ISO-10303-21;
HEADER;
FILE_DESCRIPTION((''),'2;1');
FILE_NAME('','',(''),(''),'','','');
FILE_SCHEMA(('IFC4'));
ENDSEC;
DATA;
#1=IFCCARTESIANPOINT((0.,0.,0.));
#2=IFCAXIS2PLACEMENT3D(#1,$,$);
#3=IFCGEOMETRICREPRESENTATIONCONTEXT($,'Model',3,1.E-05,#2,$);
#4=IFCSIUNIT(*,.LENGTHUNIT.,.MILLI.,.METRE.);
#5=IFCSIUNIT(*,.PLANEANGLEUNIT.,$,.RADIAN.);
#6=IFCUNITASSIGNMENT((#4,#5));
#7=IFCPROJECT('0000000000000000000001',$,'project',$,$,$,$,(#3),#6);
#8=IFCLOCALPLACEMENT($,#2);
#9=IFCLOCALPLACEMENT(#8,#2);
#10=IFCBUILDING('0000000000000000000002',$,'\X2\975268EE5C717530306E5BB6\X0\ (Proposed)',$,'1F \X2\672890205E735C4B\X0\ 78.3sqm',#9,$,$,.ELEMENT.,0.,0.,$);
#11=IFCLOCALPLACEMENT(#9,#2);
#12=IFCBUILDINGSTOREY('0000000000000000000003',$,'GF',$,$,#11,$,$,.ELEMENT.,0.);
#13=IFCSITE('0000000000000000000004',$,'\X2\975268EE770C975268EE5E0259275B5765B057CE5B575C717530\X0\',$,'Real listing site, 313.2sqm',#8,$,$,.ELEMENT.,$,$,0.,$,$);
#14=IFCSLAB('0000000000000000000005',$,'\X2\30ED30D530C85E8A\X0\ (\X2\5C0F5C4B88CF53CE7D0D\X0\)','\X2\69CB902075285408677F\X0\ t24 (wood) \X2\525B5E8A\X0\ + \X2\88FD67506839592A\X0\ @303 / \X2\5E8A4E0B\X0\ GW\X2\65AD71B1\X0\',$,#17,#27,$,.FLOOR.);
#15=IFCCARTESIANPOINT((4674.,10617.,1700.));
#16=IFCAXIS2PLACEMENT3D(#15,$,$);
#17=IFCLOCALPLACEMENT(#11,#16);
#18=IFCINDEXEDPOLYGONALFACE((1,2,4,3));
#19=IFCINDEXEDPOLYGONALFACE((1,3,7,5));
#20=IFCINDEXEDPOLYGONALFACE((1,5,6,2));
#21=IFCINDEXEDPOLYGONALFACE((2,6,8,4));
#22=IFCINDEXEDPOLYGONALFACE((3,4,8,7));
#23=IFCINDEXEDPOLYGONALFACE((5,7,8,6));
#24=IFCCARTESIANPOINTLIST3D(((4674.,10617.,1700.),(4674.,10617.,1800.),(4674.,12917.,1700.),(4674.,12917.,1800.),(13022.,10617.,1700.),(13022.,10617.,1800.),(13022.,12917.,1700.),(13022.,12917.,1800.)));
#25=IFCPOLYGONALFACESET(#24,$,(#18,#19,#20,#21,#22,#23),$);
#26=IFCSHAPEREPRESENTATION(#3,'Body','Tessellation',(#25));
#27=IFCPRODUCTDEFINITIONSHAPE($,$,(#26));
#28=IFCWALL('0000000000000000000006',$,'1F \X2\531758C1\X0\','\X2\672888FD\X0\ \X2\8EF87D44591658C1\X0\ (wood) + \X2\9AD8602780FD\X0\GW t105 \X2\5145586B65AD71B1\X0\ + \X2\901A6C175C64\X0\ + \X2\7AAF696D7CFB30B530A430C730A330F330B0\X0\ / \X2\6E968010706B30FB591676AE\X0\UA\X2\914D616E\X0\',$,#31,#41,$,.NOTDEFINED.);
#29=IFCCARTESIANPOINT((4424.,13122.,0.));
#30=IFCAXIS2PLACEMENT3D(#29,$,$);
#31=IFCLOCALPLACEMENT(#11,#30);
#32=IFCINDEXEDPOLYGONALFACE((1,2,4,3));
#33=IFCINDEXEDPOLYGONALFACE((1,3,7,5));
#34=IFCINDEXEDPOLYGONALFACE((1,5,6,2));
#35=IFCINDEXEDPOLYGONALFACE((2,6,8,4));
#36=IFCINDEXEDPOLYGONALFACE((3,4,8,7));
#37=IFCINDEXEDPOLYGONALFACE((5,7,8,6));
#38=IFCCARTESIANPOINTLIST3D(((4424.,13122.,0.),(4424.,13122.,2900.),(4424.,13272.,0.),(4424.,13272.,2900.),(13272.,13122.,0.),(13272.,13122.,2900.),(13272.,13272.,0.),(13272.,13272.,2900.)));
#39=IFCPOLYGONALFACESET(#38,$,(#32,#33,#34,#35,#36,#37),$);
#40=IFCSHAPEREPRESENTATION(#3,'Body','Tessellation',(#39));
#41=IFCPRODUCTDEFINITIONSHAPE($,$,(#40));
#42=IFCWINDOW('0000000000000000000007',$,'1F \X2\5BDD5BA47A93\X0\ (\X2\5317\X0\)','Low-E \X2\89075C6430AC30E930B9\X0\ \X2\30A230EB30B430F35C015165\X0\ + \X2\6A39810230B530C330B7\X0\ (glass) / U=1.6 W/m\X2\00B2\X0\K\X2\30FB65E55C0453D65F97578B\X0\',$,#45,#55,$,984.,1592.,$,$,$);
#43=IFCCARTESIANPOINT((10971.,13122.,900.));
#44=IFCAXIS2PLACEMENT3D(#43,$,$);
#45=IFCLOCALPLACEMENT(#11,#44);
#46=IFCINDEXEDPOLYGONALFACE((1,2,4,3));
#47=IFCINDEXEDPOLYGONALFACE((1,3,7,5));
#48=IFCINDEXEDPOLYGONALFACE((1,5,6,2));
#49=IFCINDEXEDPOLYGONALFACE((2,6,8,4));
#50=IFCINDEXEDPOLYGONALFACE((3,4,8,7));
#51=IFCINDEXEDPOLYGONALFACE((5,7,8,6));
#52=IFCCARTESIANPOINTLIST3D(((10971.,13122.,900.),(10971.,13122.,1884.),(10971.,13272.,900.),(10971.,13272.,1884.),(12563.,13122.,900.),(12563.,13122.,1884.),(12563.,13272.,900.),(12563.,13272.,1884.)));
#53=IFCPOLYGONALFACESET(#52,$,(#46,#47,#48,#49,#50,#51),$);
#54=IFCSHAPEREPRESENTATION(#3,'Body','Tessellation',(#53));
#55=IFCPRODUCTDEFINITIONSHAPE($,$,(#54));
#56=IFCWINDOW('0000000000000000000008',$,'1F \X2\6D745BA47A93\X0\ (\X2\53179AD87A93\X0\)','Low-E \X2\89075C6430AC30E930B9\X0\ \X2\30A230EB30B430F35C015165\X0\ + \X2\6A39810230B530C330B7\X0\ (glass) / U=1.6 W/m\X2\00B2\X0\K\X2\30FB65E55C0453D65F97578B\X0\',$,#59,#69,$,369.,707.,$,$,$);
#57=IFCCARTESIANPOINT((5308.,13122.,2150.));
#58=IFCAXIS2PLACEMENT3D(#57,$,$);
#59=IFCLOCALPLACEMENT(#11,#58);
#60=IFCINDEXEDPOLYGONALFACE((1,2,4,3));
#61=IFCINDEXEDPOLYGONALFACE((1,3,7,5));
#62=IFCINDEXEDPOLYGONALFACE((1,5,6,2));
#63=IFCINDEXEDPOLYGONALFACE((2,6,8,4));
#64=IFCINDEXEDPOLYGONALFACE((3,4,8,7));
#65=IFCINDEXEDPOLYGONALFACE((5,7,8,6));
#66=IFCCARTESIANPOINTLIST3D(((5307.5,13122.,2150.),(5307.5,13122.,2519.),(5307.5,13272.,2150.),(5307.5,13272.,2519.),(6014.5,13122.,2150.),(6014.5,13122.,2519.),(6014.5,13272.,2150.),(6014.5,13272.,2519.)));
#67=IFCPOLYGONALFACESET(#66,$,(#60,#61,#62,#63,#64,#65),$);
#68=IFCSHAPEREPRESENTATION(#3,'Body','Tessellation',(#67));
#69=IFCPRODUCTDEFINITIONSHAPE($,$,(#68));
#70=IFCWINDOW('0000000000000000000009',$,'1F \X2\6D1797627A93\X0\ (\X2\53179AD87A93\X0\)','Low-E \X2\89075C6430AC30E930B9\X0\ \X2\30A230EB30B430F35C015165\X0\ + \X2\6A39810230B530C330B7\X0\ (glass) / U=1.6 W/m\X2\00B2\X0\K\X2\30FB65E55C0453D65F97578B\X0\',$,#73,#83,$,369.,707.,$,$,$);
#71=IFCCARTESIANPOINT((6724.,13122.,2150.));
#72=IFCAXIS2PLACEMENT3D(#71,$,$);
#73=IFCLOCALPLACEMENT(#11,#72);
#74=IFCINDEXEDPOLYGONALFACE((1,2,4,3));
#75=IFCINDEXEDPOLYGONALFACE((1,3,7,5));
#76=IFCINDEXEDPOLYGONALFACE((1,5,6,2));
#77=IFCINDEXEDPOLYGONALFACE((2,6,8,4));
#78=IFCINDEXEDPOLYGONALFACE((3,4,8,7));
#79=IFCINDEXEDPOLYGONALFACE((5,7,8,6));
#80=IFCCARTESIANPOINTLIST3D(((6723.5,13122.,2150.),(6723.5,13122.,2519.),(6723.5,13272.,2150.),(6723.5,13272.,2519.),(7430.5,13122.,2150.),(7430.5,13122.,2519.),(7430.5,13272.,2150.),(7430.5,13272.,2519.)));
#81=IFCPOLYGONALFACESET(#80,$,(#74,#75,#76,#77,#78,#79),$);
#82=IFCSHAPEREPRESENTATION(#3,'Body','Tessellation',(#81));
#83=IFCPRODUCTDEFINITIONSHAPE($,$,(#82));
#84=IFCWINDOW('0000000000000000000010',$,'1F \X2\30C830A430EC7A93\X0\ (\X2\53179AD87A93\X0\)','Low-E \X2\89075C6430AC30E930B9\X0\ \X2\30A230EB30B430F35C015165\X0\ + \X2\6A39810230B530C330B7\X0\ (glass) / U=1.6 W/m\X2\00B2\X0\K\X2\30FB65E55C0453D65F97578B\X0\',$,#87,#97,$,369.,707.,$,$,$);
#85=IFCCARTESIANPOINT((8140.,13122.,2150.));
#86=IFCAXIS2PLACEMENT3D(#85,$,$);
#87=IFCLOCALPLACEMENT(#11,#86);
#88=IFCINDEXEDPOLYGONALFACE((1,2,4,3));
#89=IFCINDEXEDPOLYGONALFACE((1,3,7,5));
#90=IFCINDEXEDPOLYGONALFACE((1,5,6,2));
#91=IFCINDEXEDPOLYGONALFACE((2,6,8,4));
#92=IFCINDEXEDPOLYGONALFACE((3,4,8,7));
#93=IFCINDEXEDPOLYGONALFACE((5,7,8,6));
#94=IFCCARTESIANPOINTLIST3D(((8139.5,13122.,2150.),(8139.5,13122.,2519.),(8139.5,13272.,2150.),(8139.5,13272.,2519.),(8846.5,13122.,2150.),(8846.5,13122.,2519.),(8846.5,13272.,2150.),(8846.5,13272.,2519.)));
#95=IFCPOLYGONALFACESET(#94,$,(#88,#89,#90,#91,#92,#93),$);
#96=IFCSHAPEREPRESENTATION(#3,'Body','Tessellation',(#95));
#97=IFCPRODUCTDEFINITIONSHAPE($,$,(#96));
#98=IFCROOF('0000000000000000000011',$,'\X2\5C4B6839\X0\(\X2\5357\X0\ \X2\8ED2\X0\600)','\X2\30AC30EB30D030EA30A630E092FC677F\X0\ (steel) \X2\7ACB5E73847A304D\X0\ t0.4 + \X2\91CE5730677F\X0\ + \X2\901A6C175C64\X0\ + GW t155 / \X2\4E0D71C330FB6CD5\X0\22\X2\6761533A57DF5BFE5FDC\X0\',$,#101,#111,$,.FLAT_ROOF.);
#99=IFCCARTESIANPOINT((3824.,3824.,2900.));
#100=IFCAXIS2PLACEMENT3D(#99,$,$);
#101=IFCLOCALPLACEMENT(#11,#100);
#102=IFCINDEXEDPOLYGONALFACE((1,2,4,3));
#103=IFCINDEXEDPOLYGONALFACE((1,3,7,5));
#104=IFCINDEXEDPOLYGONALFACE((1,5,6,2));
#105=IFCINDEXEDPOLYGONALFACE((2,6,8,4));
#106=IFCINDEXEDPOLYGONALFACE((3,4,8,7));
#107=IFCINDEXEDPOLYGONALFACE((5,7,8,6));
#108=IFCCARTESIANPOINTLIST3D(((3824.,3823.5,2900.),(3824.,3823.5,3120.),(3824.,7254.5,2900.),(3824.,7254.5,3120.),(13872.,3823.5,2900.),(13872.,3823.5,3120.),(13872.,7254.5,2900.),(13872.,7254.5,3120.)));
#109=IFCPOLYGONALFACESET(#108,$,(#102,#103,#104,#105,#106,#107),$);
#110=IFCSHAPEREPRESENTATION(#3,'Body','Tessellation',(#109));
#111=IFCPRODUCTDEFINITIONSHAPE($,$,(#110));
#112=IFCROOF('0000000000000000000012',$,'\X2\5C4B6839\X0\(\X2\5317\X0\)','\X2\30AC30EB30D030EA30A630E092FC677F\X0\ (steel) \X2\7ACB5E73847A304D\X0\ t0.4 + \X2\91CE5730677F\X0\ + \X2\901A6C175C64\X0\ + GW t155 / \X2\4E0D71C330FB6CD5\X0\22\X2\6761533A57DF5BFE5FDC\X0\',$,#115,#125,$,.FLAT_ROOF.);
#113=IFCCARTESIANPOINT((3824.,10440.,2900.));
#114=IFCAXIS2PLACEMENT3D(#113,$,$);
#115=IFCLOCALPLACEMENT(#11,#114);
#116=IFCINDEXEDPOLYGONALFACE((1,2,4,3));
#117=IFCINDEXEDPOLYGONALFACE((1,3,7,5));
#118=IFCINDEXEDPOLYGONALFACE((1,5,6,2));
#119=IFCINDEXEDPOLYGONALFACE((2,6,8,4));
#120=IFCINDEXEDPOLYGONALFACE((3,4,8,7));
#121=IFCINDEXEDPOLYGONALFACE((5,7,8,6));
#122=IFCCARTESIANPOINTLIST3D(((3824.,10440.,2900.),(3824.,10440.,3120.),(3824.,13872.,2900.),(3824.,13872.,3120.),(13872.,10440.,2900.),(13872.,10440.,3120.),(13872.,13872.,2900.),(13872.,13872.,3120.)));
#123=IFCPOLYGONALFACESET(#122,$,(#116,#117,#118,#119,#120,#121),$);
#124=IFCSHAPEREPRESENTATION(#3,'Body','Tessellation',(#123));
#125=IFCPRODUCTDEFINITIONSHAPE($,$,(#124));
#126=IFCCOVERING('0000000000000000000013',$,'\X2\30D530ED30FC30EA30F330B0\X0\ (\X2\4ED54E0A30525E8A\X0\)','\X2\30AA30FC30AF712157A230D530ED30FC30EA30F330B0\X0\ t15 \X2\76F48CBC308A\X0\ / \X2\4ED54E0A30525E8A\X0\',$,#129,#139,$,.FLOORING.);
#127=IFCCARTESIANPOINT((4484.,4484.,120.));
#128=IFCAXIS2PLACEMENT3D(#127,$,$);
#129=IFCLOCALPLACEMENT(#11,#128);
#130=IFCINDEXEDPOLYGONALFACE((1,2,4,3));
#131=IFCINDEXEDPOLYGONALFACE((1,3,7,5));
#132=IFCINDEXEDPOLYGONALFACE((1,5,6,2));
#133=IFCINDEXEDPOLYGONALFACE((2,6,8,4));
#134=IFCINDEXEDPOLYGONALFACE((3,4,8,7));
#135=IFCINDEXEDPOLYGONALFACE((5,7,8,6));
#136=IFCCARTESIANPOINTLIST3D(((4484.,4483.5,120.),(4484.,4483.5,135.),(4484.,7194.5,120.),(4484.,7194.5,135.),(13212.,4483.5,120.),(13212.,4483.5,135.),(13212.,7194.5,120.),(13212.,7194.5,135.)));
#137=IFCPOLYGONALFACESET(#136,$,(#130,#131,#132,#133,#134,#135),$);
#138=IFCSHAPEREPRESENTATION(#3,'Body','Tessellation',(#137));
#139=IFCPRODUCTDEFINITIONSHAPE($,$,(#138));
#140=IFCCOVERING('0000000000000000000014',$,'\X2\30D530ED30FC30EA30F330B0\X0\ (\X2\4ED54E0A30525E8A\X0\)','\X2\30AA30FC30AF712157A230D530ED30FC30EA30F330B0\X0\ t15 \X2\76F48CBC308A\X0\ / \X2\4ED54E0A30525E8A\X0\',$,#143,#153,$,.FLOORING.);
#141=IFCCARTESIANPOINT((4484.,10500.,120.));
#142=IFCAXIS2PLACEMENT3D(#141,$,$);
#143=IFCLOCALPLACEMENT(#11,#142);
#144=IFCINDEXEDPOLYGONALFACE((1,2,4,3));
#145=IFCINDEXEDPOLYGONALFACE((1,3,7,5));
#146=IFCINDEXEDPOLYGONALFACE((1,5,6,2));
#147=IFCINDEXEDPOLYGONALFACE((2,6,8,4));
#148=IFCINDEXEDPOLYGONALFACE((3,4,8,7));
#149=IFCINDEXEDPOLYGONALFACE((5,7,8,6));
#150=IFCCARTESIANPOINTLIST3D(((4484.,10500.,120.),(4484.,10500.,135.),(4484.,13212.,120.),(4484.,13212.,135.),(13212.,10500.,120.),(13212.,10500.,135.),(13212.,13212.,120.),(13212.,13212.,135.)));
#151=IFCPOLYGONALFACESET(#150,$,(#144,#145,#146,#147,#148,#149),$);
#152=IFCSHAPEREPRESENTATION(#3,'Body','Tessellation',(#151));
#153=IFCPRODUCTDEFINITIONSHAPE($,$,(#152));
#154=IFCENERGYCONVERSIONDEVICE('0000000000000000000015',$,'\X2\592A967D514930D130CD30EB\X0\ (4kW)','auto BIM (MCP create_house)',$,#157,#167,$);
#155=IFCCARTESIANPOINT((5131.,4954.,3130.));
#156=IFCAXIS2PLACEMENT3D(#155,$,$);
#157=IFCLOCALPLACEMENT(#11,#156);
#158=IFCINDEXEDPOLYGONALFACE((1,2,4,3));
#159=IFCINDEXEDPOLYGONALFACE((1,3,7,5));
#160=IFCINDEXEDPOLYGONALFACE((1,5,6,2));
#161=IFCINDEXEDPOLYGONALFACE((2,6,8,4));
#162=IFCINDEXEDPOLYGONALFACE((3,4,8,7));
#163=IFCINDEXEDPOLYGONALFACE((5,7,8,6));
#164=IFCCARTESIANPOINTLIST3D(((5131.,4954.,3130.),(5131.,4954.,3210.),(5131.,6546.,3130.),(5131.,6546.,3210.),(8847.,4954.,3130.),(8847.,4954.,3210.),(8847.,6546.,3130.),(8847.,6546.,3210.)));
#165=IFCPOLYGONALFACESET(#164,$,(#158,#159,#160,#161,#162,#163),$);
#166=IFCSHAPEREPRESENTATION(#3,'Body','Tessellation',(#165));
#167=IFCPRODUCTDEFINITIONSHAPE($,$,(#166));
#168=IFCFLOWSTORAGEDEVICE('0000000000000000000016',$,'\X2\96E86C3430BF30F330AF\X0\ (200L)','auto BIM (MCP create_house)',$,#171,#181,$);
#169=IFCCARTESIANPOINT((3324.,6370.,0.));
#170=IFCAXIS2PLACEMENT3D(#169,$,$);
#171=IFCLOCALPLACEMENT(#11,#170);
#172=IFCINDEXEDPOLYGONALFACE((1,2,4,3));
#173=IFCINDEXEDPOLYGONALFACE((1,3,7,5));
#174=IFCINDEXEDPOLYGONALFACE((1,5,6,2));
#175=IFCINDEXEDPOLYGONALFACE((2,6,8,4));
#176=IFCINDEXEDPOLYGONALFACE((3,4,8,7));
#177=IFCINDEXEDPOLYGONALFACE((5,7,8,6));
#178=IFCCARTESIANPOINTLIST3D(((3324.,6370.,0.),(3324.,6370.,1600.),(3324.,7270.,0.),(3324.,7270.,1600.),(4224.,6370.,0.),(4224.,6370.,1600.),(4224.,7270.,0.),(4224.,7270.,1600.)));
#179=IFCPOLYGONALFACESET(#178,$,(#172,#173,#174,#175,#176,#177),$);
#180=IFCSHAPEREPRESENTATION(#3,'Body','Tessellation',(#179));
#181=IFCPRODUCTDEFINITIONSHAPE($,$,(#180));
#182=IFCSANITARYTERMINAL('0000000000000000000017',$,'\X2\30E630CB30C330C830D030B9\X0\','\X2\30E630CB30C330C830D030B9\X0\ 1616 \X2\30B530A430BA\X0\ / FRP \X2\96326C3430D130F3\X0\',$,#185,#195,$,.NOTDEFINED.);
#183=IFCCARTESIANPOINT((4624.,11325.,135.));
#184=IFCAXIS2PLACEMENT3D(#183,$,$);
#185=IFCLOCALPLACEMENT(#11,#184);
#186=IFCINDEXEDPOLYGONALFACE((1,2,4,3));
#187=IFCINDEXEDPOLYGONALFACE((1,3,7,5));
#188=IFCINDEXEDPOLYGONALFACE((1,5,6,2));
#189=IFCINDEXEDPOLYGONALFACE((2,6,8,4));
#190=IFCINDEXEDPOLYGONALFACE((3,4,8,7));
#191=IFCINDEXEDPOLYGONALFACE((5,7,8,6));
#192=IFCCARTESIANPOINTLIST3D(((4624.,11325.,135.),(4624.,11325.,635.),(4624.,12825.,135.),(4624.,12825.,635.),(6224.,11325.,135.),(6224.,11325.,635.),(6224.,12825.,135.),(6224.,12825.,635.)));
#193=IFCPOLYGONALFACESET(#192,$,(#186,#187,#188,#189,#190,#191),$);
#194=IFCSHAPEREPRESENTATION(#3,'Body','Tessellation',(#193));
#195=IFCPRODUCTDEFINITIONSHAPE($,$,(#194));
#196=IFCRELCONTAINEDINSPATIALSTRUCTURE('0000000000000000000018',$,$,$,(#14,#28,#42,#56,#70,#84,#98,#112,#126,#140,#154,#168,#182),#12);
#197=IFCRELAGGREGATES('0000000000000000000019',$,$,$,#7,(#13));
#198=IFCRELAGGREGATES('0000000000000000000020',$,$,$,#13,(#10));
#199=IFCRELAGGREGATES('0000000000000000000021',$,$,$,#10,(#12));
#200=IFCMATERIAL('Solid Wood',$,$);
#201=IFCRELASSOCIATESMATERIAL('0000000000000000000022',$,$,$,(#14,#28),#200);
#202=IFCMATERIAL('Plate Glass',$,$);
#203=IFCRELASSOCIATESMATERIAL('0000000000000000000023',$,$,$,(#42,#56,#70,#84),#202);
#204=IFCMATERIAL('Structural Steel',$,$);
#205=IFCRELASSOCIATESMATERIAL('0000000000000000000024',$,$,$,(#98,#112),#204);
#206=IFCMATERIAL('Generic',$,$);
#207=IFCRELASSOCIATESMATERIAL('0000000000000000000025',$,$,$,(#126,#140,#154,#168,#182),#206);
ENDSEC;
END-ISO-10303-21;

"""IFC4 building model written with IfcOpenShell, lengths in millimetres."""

from ifc_helpers import new_model, si_unit, frame, frame_2d, origin, place, context, project, spatial, rectangle, extrude, material, element, fill, save


model = new_model("IFC4")

# Units and contexts
model_context = context("Model", 3, precision=1e-05, world=origin())
ifc_project = project(units=[si_unit("LENGTHUNIT", "METRE", prefix="MILLI"), si_unit("PLANEANGLEUNIT", "RADIAN")], contexts=[model_context])

# Site, building, storey
site_placement = place(None, origin())
site = spatial("IfcSite", under=ifc_project, at=site_placement, Name="青森県青森市大字新城字山田", ObjectType="Real listing site, 313.2sqm", CompositionType="ELEMENT", RefElevation=0.0)
building_placement = place(site_placement, origin())
building = spatial("IfcBuilding", under=site, at=building_placement, Name="青森山田の家 (Proposed)", ObjectType="1F 木造平屋 78.3sqm", CompositionType="ELEMENT", ElevationOfRefHeight=0.0, ElevationOfTerrain=0.0)
storey_placement = place(building_placement, origin())
storey = spatial("IfcBuildingStorey", under=building, at=storey_placement, Name="GF", CompositionType="ELEMENT", Elevation=0.0)

# Slab
ifc_material_1 = material(Name="Solid Wood")
slab_1_placement = place(storey_placement, frame((4674.0, 10617.0, 1700.0)))
element("IfcSlab", 1, at=slab_1_placement, inside=storey, material=ifc_material_1, Name="ロフト床 (小屋裏収納)", Description="構造用合板 t24 (wood) 剛床 + 製材根太 @303 / 床下 GW断熱", PredefinedType="FLOOR", context=model_context, shape_type="SweptSolid", body=[
    extrude(rectangle(XDim=8348.0, YDim=2300.0, at=frame_2d((4174.0, 1150.0))), frame((4674.0, 10617.0, 1700.0)), (0.0, 0.0, 1.0), 100.0),
])

# Shared definitions
ifc_material_2 = material(Name="Plate Glass")

# Wall, openings, windows
wall_1_placement = place(storey_placement, frame((4424.0, 13122.0, 0.0)))
wall_1 = element("IfcWall", 2, at=wall_1_placement, inside=storey, material=ifc_material_1, Name="1F 北壁", Description="木製 軸組外壁 (wood) + 高性能GW t105 充填断熱 + 通気層 + 窯業系サイディング / 準耐火・外皮UA配慮", PredefinedType="NOTDEFINED", context=model_context, shape_type="SweptSolid", body=[
    extrude(rectangle(XDim=8848.0, YDim=150.0, at=frame_2d((4424.0, 75.0))), frame((4424.0, 13122.0, 0.0)), (0.0, 0.0, 1.0), 2900.0),
])
opening_1_placement = place(storey_placement, frame((10971.0, 13122.0, 900.0)))
opening_1 = element("IfcOpeningElement", 3, at=opening_1_placement, cuts=wall_1, PredefinedType="NOTDEFINED", context=model_context, shape_type="SweptSolid", body=[
    extrude(rectangle(XDim=1592.0, YDim=150.0, at=frame_2d((796.0, 75.0))), frame((10971.0, 13122.0, 900.0)), (0.0, 0.0, 1.0), 984.0),
])
opening_2_placement = place(storey_placement, frame((5308.0, 13122.0, 2150.0)))
opening_2 = element("IfcOpeningElement", 4, at=opening_2_placement, cuts=wall_1, PredefinedType="NOTDEFINED", context=model_context, shape_type="SweptSolid", body=[
    extrude(rectangle(XDim=707.0, YDim=150.0, at=frame_2d((353.0, 75.0))), frame((5308.0, 13122.0, 2150.0)), (0.0, 0.0, 1.0), 369.0),
])
opening_3_placement = place(storey_placement, frame((6724.0, 13122.0, 2150.0)))
opening_3 = element("IfcOpeningElement", 5, at=opening_3_placement, cuts=wall_1, PredefinedType="NOTDEFINED", context=model_context, shape_type="SweptSolid", body=[
    extrude(rectangle(XDim=707.0, YDim=150.0, at=frame_2d((353.0, 75.0))), frame((6724.0, 13122.0, 2150.0)), (0.0, 0.0, 1.0), 369.0),
])
opening_4_placement = place(storey_placement, frame((8140.0, 13122.0, 2150.0)))
opening_4 = element("IfcOpeningElement", 6, at=opening_4_placement, cuts=wall_1, PredefinedType="NOTDEFINED", context=model_context, shape_type="SweptSolid", body=[
    extrude(rectangle(XDim=707.0, YDim=150.0, at=frame_2d((353.0, 75.0))), frame((8140.0, 13122.0, 2150.0)), (0.0, 0.0, 1.0), 369.0),
])
window_1_placement = place(storey_placement, frame((10971.0, 13122.0, 900.0)))
window_1 = element("IfcWindow", 7, at=window_1_placement, inside=storey, material=ifc_material_2, Name="1F 寝室窓 (北)", Description="Low-E 複層ガラス アルゴン封入 + 樹脂サッシ (glass) / U=1.6 W/m²K・日射取得型", OverallHeight=984.0, OverallWidth=1592.0, context=model_context, shape_type="SweptSolid", body=[
    extrude(rectangle(XDim=1592.0, YDim=150.0, at=frame_2d((796.0, 75.0))), frame((10971.0, 13122.0, 900.0)), (0.0, 0.0, 1.0), 984.0),
])
fill(opening_1, window_1)
window_2_placement = place(storey_placement, frame((5308.0, 13122.0, 2150.0)))
window_2 = element("IfcWindow", 8, at=window_2_placement, inside=storey, material=ifc_material_2, Name="1F 浴室窓 (北高窓)", Description="Low-E 複層ガラス アルゴン封入 + 樹脂サッシ (glass) / U=1.6 W/m²K・日射取得型", OverallHeight=369.0, OverallWidth=707.0, context=model_context, shape_type="SweptSolid", body=[
    extrude(rectangle(XDim=707.0, YDim=150.0, at=frame_2d((353.0, 75.0))), frame((5308.0, 13122.0, 2150.0)), (0.0, 0.0, 1.0), 369.0),
])
fill(opening_2, window_2)
window_3_placement = place(storey_placement, frame((6724.0, 13122.0, 2150.0)))
window_3 = element("IfcWindow", 9, at=window_3_placement, inside=storey, material=ifc_material_2, Name="1F 洗面窓 (北高窓)", Description="Low-E 複層ガラス アルゴン封入 + 樹脂サッシ (glass) / U=1.6 W/m²K・日射取得型", OverallHeight=369.0, OverallWidth=707.0, context=model_context, shape_type="SweptSolid", body=[
    extrude(rectangle(XDim=707.0, YDim=150.0, at=frame_2d((353.0, 75.0))), frame((6724.0, 13122.0, 2150.0)), (0.0, 0.0, 1.0), 369.0),
])
fill(opening_3, window_3)
window_4_placement = place(storey_placement, frame((8140.0, 13122.0, 2150.0)))
window_4 = element("IfcWindow", 10, at=window_4_placement, inside=storey, material=ifc_material_2, Name="1F トイレ窓 (北高窓)", Description="Low-E 複層ガラス アルゴン封入 + 樹脂サッシ (glass) / U=1.6 W/m²K・日射取得型", OverallHeight=369.0, OverallWidth=707.0, context=model_context, shape_type="SweptSolid", body=[
    extrude(rectangle(XDim=707.0, YDim=150.0, at=frame_2d((353.0, 75.0))), frame((8140.0, 13122.0, 2150.0)), (0.0, 0.0, 1.0), 369.0),
])
fill(opening_4, window_4)

# Roofs
ifc_material_3 = material(Name="Structural Steel")
roof_1_placement = place(storey_placement, frame((3824.0, 3824.0, 2900.0)))
element("IfcRoof", 11, at=roof_1_placement, inside=storey, material=ifc_material_3, Name="屋根(南 軒600)", Description="ガルバリウム鋼板 (steel) 立平葺き t0.4 + 野地板 + 通気層 + GW t155 / 不燃・法22条区域対応", PredefinedType="FLAT_ROOF", context=model_context, shape_type="SweptSolid", body=[
    extrude(rectangle(XDim=10048.0, YDim=3431.0, at=frame_2d((5024.0, 1715.0))), frame((3824.0, 3824.0, 2900.0)), (0.0, 0.0, 1.0), 220.0),
])
roof_2_placement = place(storey_placement, frame((3824.0, 10440.0, 2900.0)))
element("IfcRoof", 12, at=roof_2_placement, inside=storey, material=ifc_material_3, Name="屋根(北)", Description="ガルバリウム鋼板 (steel) 立平葺き t0.4 + 野地板 + 通気層 + GW t155 / 不燃・法22条区域対応", PredefinedType="FLAT_ROOF", context=model_context, shape_type="SweptSolid", body=[
    extrude(rectangle(XDim=10048.0, YDim=3432.0, at=frame_2d((5024.0, 1716.0))), frame((3824.0, 10440.0, 2900.0)), (0.0, 0.0, 1.0), 220.0),
])

# Coverings
ifc_material_4 = material(Name="Generic")
covering_1_placement = place(storey_placement, frame((4484.0, 4484.0, 120.0)))
element("IfcCovering", 13, at=covering_1_placement, inside=storey, material=ifc_material_4, Name="フローリング (仕上げ床)", Description="オーク無垢フローリング t15 直貼り / 仕上げ床", PredefinedType="FLOORING", context=model_context, shape_type="SweptSolid", body=[
    extrude(rectangle(XDim=8728.0, YDim=2711.0, at=frame_2d((4364.0, 1355.0))), frame((4484.0, 4484.0, 120.0)), (0.0, 0.0, 1.0), 15.0),
])
covering_2_placement = place(storey_placement, frame((4484.0, 10500.0, 120.0)))
element("IfcCovering", 14, at=covering_2_placement, inside=storey, material=ifc_material_4, Name="フローリング (仕上げ床)", Description="オーク無垢フローリング t15 直貼り / 仕上げ床", PredefinedType="FLOORING", context=model_context, shape_type="SweptSolid", body=[
    extrude(rectangle(XDim=8728.0, YDim=2712.0, at=frame_2d((4364.0, 1356.0))), frame((4484.0, 10500.0, 120.0)), (0.0, 0.0, 1.0), 15.0),
])

# Energy conversion device
energy_conversion_device_placement = place(storey_placement, frame((5131.0, 4954.0, 3130.0)))
element("IfcEnergyConversionDevice", 15, at=energy_conversion_device_placement, inside=storey, material=ifc_material_4, Name="太陽光パネル (4kW)", Description="auto BIM (MCP create_house)", context=model_context, shape_type="SweptSolid", body=[
    extrude(rectangle(XDim=3716.0, YDim=1592.0, at=frame_2d((1858.0, 796.0))), frame((5131.0, 4954.0, 3130.0)), (0.0, 0.0, 1.0), 80.0),
])

# Flow storage device
flow_storage_device_placement = place(storey_placement, frame((3324.0, 6370.0, 0.0)))
element("IfcFlowStorageDevice", 16, at=flow_storage_device_placement, inside=storey, material=ifc_material_4, Name="雨水タンク (200L)", Description="auto BIM (MCP create_house)", context=model_context, shape_type="SweptSolid", body=[
    extrude(rectangle(XDim=900.0, YDim=900.0, at=frame_2d((450.0, 450.0))), frame((3324.0, 6370.0, 0.0)), (0.0, 0.0, 1.0), 1600.0),
])

# Sanitary terminal
sanitary_terminal_placement = place(storey_placement, frame((4624.0, 11325.0, 135.0)))
element("IfcSanitaryTerminal", 17, at=sanitary_terminal_placement, inside=storey, material=ifc_material_4, Name="ユニットバス", Description="ユニットバス 1616 サイズ / FRP 防水パン", PredefinedType="NOTDEFINED", context=model_context, shape_type="SweptSolid", body=[
    extrude(rectangle(XDim=1600.0, YDim=1500.0, at=frame_2d((800.0, 750.0))), frame((4624.0, 11325.0, 135.0)), (0.0, 0.0, 1.0), 500.0),
])

save(model, "model.ifc")
